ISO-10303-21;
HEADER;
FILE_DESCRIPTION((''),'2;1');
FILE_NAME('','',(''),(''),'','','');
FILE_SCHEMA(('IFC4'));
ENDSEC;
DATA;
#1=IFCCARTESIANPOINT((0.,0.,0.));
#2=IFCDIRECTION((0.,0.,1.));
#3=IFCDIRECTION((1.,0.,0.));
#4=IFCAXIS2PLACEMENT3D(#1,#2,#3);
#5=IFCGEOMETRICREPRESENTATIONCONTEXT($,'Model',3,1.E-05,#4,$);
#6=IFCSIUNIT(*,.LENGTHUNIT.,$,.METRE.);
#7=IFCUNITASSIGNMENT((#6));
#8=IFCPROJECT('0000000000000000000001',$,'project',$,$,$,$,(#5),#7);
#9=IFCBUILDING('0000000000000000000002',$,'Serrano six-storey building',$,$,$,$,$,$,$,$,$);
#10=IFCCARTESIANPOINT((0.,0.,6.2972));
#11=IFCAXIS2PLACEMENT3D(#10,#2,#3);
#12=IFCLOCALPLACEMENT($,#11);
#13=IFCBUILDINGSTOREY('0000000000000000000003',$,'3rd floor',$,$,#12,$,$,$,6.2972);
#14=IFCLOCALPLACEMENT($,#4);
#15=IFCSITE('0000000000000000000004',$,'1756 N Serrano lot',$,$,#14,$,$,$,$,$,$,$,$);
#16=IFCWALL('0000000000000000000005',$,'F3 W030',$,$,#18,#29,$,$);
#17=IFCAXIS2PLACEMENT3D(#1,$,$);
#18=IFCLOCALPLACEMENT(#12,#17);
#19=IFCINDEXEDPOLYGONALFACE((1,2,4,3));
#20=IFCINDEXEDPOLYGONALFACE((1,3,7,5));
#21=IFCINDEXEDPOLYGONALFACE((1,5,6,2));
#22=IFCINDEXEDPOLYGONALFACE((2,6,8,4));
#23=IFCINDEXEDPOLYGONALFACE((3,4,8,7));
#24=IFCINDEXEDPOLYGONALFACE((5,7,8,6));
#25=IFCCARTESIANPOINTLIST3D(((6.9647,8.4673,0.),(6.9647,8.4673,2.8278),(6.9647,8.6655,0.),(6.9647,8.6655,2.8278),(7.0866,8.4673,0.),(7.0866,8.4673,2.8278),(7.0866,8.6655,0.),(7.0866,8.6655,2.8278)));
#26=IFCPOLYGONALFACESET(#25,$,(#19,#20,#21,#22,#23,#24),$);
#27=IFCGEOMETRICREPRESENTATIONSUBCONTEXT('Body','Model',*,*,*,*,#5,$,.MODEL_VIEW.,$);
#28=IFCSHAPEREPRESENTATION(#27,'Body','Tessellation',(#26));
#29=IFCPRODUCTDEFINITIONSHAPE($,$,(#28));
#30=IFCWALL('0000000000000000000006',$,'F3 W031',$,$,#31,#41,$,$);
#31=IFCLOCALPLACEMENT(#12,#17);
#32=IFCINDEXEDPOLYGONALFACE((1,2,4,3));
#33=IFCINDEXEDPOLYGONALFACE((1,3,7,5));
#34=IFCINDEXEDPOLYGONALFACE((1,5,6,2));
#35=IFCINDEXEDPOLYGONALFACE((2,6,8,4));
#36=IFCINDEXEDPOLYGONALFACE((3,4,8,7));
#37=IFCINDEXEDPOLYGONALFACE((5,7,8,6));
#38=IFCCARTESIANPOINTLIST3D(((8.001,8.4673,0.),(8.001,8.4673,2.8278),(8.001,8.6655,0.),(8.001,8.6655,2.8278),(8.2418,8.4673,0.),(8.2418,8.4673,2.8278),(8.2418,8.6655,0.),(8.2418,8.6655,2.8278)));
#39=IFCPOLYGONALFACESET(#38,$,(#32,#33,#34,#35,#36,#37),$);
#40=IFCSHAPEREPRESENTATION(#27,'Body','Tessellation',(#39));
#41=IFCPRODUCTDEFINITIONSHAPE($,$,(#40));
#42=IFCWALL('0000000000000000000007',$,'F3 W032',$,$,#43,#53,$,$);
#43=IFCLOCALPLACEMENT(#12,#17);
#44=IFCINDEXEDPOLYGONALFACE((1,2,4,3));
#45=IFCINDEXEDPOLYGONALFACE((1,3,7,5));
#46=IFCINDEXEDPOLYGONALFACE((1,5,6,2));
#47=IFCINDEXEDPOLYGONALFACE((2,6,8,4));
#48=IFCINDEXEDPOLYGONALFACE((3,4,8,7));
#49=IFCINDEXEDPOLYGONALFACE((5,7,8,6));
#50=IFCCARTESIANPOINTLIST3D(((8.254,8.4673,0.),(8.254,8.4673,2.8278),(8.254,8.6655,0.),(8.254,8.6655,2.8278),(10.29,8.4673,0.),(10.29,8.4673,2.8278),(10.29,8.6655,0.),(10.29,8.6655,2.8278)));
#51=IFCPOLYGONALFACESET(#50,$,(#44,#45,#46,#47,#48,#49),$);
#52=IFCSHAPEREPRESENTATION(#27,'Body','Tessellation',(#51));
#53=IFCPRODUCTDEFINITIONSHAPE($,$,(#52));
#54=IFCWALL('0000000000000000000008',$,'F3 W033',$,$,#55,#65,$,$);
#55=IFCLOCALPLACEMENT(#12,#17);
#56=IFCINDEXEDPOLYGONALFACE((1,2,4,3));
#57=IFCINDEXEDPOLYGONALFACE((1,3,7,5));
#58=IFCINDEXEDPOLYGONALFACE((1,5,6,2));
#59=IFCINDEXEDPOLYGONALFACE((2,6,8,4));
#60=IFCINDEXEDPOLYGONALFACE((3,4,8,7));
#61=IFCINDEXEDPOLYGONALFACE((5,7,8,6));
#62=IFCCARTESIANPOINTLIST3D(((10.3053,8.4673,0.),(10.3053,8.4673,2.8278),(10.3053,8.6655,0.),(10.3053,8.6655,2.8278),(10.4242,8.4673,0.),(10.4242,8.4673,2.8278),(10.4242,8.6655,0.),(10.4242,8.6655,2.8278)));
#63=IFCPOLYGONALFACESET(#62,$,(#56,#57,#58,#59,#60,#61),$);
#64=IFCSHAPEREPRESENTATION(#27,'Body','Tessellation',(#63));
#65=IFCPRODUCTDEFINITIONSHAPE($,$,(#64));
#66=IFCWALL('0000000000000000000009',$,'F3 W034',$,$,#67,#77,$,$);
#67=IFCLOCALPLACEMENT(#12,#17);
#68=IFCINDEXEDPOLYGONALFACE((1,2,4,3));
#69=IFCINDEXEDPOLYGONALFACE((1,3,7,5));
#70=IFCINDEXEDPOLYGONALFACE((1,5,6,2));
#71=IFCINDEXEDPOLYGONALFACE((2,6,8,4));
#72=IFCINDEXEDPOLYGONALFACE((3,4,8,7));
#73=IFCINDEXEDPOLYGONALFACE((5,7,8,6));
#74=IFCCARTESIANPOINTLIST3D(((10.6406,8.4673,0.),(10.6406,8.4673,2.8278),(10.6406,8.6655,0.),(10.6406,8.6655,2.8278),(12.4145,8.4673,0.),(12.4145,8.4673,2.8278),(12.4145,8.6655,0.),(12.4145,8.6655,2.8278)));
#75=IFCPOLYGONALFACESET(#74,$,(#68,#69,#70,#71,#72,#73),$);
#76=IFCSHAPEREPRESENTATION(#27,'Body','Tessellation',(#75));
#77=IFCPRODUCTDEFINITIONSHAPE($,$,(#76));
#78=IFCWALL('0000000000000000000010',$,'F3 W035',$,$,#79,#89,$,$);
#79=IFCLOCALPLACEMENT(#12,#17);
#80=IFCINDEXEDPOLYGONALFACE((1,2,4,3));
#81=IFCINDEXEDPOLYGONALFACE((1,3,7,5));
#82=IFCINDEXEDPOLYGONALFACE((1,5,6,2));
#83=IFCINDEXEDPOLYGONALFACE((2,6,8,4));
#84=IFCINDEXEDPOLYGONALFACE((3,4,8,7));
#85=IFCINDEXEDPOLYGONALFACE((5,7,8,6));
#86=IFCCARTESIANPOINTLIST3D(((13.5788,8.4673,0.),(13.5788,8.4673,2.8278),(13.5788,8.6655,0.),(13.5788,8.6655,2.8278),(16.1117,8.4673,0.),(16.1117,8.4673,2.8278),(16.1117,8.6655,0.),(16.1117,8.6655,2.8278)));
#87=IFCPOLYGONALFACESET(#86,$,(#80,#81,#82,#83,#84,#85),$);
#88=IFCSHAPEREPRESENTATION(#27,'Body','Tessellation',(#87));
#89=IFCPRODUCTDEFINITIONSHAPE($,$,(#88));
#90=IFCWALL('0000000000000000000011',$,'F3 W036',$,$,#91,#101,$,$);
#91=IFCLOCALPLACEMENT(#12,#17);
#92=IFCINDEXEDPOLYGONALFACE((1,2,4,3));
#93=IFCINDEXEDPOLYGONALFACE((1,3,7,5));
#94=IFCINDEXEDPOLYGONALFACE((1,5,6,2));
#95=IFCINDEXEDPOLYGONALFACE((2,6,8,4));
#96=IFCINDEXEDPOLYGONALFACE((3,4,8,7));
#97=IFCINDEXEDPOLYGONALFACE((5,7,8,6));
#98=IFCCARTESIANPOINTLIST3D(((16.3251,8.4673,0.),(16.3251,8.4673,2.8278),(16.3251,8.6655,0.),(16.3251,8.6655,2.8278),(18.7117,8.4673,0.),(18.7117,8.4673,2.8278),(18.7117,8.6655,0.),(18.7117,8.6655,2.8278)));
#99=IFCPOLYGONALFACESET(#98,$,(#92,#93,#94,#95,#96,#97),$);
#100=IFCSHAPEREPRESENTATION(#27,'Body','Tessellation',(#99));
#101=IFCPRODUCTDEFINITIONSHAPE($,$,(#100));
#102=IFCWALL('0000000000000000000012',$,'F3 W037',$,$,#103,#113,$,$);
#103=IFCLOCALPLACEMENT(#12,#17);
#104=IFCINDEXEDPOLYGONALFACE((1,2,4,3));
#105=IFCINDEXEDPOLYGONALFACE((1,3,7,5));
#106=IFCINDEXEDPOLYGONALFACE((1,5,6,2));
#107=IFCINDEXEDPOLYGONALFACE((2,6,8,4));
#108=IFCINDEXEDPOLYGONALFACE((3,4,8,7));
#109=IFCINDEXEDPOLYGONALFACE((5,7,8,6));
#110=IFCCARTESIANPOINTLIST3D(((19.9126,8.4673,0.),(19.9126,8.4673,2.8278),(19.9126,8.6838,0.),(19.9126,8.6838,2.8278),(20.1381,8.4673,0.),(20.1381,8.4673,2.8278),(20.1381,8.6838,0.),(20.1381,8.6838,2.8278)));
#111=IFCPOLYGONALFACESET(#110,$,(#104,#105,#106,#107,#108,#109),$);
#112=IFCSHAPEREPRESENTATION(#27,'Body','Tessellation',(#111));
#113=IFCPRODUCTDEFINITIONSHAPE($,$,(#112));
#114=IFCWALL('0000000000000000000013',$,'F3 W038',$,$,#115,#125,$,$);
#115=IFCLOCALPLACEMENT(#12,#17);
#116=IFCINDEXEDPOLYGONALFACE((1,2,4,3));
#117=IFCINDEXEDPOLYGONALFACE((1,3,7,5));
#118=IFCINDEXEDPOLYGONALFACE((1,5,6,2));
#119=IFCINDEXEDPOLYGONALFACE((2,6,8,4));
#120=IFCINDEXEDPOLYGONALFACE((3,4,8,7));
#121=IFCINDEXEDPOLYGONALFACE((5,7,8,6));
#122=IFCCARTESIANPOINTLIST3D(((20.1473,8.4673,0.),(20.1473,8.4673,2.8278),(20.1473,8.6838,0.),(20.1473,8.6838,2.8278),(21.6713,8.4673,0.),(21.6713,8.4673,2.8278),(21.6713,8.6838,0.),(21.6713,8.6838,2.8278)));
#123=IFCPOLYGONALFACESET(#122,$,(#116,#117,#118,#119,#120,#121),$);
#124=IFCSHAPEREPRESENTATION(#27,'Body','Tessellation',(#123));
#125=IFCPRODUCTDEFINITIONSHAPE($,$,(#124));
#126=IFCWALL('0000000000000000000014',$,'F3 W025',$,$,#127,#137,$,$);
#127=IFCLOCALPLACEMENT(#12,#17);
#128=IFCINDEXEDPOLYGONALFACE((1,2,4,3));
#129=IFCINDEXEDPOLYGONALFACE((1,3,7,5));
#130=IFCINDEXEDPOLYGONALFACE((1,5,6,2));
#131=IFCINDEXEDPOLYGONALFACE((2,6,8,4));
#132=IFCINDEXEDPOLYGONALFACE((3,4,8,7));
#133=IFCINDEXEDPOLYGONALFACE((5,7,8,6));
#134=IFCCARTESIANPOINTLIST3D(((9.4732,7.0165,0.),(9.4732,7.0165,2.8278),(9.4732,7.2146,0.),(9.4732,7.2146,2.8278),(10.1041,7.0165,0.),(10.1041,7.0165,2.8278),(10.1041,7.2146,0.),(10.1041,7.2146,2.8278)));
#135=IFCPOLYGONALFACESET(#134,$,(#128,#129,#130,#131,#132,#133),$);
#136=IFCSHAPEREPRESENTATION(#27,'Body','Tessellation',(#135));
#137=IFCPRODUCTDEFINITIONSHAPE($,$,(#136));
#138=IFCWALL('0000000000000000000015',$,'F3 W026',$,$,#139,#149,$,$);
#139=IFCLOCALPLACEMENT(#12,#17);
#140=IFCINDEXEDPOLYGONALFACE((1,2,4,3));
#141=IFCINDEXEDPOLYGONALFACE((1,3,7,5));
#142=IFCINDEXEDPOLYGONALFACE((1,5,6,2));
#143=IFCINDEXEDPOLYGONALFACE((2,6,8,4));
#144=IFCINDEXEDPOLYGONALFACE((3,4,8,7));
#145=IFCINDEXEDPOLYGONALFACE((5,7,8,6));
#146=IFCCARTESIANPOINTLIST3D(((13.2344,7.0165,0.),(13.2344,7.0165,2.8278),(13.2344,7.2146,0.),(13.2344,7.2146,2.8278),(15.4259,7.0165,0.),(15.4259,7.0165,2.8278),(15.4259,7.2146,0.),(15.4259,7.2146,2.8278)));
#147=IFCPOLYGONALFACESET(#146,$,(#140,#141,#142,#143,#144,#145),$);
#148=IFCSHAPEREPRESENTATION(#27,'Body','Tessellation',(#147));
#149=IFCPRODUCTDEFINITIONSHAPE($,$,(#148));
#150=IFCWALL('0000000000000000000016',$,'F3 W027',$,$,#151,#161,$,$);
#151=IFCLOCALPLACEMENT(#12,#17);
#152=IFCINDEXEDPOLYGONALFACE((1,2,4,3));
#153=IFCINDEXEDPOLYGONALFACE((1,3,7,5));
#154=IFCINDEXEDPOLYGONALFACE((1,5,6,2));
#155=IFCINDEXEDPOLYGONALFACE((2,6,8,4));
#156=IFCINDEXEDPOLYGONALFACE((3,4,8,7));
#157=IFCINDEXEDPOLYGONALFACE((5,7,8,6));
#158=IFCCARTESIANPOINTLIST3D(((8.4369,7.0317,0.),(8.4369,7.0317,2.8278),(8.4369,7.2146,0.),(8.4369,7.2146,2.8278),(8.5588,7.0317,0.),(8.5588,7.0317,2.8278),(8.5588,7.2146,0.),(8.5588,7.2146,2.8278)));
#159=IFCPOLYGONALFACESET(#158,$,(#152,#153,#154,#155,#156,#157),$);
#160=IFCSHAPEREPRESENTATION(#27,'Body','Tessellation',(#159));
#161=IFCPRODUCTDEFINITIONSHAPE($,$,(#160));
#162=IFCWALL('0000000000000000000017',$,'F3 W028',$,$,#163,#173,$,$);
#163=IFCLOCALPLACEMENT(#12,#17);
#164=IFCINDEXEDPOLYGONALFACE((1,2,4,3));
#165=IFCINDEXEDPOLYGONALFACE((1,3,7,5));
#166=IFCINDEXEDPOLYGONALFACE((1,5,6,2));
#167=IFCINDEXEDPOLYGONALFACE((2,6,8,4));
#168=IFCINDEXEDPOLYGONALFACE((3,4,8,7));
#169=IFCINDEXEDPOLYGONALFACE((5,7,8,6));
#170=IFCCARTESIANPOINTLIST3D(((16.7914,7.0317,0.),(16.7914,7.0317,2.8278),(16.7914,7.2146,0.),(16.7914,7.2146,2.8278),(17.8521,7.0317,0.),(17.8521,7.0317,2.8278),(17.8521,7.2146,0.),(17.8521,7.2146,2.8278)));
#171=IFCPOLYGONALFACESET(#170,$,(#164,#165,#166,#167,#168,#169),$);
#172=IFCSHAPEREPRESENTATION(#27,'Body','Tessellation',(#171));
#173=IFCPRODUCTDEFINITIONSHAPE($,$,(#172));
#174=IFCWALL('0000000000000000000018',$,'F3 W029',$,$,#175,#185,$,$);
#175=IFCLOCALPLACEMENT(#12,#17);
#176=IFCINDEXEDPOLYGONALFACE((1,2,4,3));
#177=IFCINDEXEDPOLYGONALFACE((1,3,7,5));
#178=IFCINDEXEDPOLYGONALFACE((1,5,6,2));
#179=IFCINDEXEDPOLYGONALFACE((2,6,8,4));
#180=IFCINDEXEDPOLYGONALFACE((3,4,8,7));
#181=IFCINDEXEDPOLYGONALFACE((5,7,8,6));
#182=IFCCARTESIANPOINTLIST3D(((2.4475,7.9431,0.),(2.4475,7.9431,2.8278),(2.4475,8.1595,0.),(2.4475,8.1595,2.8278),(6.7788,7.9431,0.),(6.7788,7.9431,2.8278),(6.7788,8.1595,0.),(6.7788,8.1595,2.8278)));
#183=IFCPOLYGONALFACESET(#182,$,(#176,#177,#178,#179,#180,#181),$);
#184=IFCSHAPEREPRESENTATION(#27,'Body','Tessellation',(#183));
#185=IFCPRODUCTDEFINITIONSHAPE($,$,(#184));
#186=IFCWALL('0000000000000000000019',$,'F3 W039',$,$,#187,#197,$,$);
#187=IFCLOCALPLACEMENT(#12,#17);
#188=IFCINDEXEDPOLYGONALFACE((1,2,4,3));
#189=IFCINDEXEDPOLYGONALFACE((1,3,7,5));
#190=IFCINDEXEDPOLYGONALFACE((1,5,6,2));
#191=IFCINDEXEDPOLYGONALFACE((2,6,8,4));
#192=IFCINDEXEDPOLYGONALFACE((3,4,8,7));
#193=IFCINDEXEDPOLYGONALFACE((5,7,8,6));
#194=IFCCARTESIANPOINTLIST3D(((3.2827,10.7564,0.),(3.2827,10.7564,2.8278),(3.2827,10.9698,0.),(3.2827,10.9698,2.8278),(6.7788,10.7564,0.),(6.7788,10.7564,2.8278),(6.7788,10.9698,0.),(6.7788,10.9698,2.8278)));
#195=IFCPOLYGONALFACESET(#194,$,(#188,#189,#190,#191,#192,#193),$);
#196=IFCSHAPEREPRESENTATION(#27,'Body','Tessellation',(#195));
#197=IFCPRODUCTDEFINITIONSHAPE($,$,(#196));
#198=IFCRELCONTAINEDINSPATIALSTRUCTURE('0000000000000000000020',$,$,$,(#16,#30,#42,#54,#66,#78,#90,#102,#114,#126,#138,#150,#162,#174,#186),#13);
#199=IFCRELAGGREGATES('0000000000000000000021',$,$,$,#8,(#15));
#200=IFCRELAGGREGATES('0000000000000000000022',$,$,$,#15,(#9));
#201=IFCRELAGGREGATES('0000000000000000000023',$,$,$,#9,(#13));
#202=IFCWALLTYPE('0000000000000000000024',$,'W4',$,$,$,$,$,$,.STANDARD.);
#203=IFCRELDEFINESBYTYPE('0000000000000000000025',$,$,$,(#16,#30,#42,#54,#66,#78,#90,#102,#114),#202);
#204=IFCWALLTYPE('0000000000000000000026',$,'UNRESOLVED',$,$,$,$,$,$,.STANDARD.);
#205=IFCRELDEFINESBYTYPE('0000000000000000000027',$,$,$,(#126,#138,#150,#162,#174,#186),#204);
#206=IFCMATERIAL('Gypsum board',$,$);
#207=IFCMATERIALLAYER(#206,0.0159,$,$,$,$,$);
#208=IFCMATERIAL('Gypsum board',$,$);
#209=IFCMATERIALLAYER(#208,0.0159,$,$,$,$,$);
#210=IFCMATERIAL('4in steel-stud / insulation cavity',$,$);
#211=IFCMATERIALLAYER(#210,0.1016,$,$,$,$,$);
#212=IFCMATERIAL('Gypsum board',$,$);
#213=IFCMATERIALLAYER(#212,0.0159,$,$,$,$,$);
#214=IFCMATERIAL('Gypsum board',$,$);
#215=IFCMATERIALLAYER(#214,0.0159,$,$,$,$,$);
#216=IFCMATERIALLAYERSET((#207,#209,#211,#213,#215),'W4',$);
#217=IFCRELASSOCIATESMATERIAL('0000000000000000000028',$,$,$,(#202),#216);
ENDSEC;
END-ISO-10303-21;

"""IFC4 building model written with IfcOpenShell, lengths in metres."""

from ifc_helpers import new_model, si_unit, frame, origin_with_axes, place, context, subcontext, project, spatial, polyline, outline, extrude, material, layer, layer_set, type_object, element, save


model = new_model("IFC4")

# Units and contexts
model_context = context("Model", 3, precision=1e-05, world=origin_with_axes())
body_context = subcontext(model_context, "Body", "Model", "MODEL_VIEW")
ifc_project = project(units=[si_unit("LENGTHUNIT", "METRE")], contexts=[model_context])

# Site, building, storey
site_placement = place(None, origin_with_axes())
site = spatial("IfcSite", under=ifc_project, at=site_placement, Name="1756 N Serrano lot")
building = spatial("IfcBuilding", under=site, Name="Serrano six-storey building")
storey_placement = place(None, frame((0.0, 0.0, 6.2972), z_axis=(0.0, 0.0, 1.0), x_axis=(1.0, 0.0, 0.0)))
storey = spatial("IfcBuildingStorey", under=building, at=storey_placement, Name="3rd floor", Elevation=6.2972)

# Walls
ifc_material_1 = material(Name="Gypsum board")
ifc_layer_1 = layer(ifc_material_1, 0.0159)
ifc_material_2 = material(Name="Gypsum board")
ifc_layer_2 = layer(ifc_material_2, 0.0159)
ifc_material_3 = material(Name="4in steel-stud / insulation cavity")
ifc_layer_3 = layer(ifc_material_3, 0.1016)
ifc_material_4 = material(Name="Gypsum board")
ifc_layer_4 = layer(ifc_material_4, 0.0159)
ifc_material_5 = material(Name="Gypsum board")
ifc_layer_5 = layer(ifc_material_5, 0.0159)
ifc_layer_set = layer_set([ifc_layer_1, ifc_layer_2, ifc_layer_3, ifc_layer_4, ifc_layer_5], Name="W4")
wall_type_1 = type_object("IfcWallType", Name="W4", PredefinedType="STANDARD", material=ifc_layer_set)
wall_1_placement = place(storey_placement, frame((0.0, 0.0, -6.2972), z_axis=(0.0, 0.0, 1.0), x_axis=(1.0, 0.0, 0.0)))
element("IfcWall", 1, at=wall_1_placement, inside=storey, type_object=wall_type_1, Name="F3 W030", context=body_context, shape_type="SweptSolid", body=[
    extrude(outline(polyline([(7.0866, 8.6655), (7.0866, 8.4673), (6.9647, 8.4673), (6.9647, 8.6655), (7.0866, 8.6655)])), frame((0.0, 0.0, 6.2972)), (0.0, 0.0, 1.0), 2.8278),
])
wall_2_placement = place(storey_placement, frame((0.0, 0.0, -6.2972), z_axis=(0.0, 0.0, 1.0), x_axis=(1.0, 0.0, 0.0)))
element("IfcWall", 2, at=wall_2_placement, inside=storey, type_object=wall_type_1, Name="F3 W031", context=body_context, shape_type="SweptSolid", body=[
    extrude(outline(polyline([(8.2418, 8.6655), (8.2418, 8.4673), (8.001, 8.4673), (8.001, 8.6655), (8.2418, 8.6655)])), frame((0.0, 0.0, 6.2972)), (0.0, 0.0, 1.0), 2.8278),
])
wall_3_placement = place(storey_placement, frame((0.0, 0.0, -6.2972), z_axis=(0.0, 0.0, 1.0), x_axis=(1.0, 0.0, 0.0)))
element("IfcWall", 3, at=wall_3_placement, inside=storey, type_object=wall_type_1, Name="F3 W032", context=body_context, shape_type="SweptSolid", body=[
    extrude(outline(polyline([(10.29, 8.6655), (10.29, 8.4673), (8.254, 8.4673), (8.254, 8.6655), (10.29, 8.6655)])), frame((0.0, 0.0, 6.2972)), (0.0, 0.0, 1.0), 2.8278),
])
wall_4_placement = place(storey_placement, frame((0.0, 0.0, -6.2972), z_axis=(0.0, 0.0, 1.0), x_axis=(1.0, 0.0, 0.0)))
element("IfcWall", 4, at=wall_4_placement, inside=storey, type_object=wall_type_1, Name="F3 W033", context=body_context, shape_type="SweptSolid", body=[
    extrude(outline(polyline([(10.4242, 8.6655), (10.4242, 8.4673), (10.3053, 8.4673), (10.3053, 8.6655), (10.4242, 8.6655)])), frame((0.0, 0.0, 6.2972)), (0.0, 0.0, 1.0), 2.8278),
])
wall_5_placement = place(storey_placement, frame((0.0, 0.0, -6.2972), z_axis=(0.0, 0.0, 1.0), x_axis=(1.0, 0.0, 0.0)))
element("IfcWall", 5, at=wall_5_placement, inside=storey, type_object=wall_type_1, Name="F3 W034", context=body_context, shape_type="SweptSolid", body=[
    extrude(outline(polyline([(12.4145, 8.6655), (12.4145, 8.4673), (10.6406, 8.4673), (10.6406, 8.6655), (12.4145, 8.6655)])), frame((0.0, 0.0, 6.2972)), (0.0, 0.0, 1.0), 2.8278),
])
wall_6_placement = place(storey_placement, frame((0.0, 0.0, -6.2972), z_axis=(0.0, 0.0, 1.0), x_axis=(1.0, 0.0, 0.0)))
element("IfcWall", 6, at=wall_6_placement, inside=storey, type_object=wall_type_1, Name="F3 W035", context=body_context, shape_type="SweptSolid", body=[
    extrude(outline(polyline([(16.1117, 8.6655), (16.1117, 8.4673), (13.5788, 8.4673), (13.5788, 8.6655), (16.1117, 8.6655)])), frame((0.0, 0.0, 6.2972)), (0.0, 0.0, 1.0), 2.8278),
])
wall_7_placement = place(storey_placement, frame((0.0, 0.0, -6.2972), z_axis=(0.0, 0.0, 1.0), x_axis=(1.0, 0.0, 0.0)))
element("IfcWall", 7, at=wall_7_placement, inside=storey, type_object=wall_type_1, Name="F3 W036", context=body_context, shape_type="SweptSolid", body=[
    extrude(outline(polyline([(18.7117, 8.6655), (18.7117, 8.4673), (16.3251, 8.4673), (16.3251, 8.6655), (18.7117, 8.6655)])), frame((0.0, 0.0, 6.2972)), (0.0, 0.0, 1.0), 2.8278),
])
wall_8_placement = place(storey_placement, frame((0.0, 0.0, -6.2972), z_axis=(0.0, 0.0, 1.0), x_axis=(1.0, 0.0, 0.0)))
element("IfcWall", 8, at=wall_8_placement, inside=storey, type_object=wall_type_1, Name="F3 W037", context=body_context, shape_type="SweptSolid", body=[
    extrude(outline(polyline([(20.1381, 8.6838), (20.1381, 8.4673), (19.9126, 8.4673), (19.9126, 8.6838), (20.1381, 8.6838)])), frame((0.0, 0.0, 6.2972)), (0.0, 0.0, 1.0), 2.8278),
])
wall_9_placement = place(storey_placement, frame((0.0, 0.0, -6.2972), z_axis=(0.0, 0.0, 1.0), x_axis=(1.0, 0.0, 0.0)))
element("IfcWall", 9, at=wall_9_placement, inside=storey, type_object=wall_type_1, Name="F3 W038", context=body_context, shape_type="SweptSolid", body=[
    extrude(outline(polyline([(21.6713, 8.6838), (21.6713, 8.4673), (20.1473, 8.4673), (20.1473, 8.6838), (21.6713, 8.6838)])), frame((0.0, 0.0, 6.2972)), (0.0, 0.0, 1.0), 2.8278),
])
wall_type_2 = type_object("IfcWallType", Name="UNRESOLVED", PredefinedType="STANDARD")
wall_10_placement = place(storey_placement, frame((0.0, 0.0, -6.2972), z_axis=(0.0, 0.0, 1.0), x_axis=(1.0, 0.0, 0.0)))
element("IfcWall", 10, at=wall_10_placement, inside=storey, type_object=wall_type_2, Name="F3 W025", context=body_context, shape_type="SweptSolid", body=[
    extrude(outline(polyline([(10.1041, 7.2146), (10.1041, 7.0165), (9.4732, 7.0165), (9.4732, 7.2146), (10.1041, 7.2146)])), frame((0.0, 0.0, 6.2972)), (0.0, 0.0, 1.0), 2.8278),
])
wall_11_placement = place(storey_placement, frame((0.0, 0.0, -6.2972), z_axis=(0.0, 0.0, 1.0), x_axis=(1.0, 0.0, 0.0)))
element("IfcWall", 11, at=wall_11_placement, inside=storey, type_object=wall_type_2, Name="F3 W026", context=body_context, shape_type="SweptSolid", body=[
    extrude(outline(polyline([(15.4259, 7.2146), (15.4259, 7.0165), (13.2344, 7.0165), (13.2344, 7.2146), (15.4259, 7.2146)])), frame((0.0, 0.0, 6.2972)), (0.0, 0.0, 1.0), 2.8278),
])
wall_12_placement = place(storey_placement, frame((0.0, 0.0, -6.2972), z_axis=(0.0, 0.0, 1.0), x_axis=(1.0, 0.0, 0.0)))
element("IfcWall", 12, at=wall_12_placement, inside=storey, type_object=wall_type_2, Name="F3 W027", context=body_context, shape_type="SweptSolid", body=[
    extrude(outline(polyline([(8.5588, 7.2146), (8.5588, 7.0317), (8.4369, 7.0317), (8.4369, 7.2146), (8.5588, 7.2146)])), frame((0.0, 0.0, 6.2972)), (0.0, 0.0, 1.0), 2.8278),
])
wall_13_placement = place(storey_placement, frame((0.0, 0.0, -6.2972), z_axis=(0.0, 0.0, 1.0), x_axis=(1.0, 0.0, 0.0)))
element("IfcWall", 13, at=wall_13_placement, inside=storey, type_object=wall_type_2, Name="F3 W028", context=body_context, shape_type="SweptSolid", body=[
    extrude(outline(polyline([(17.8521, 7.2146), (17.8521, 7.0317), (16.7914, 7.0317), (16.7914, 7.2146), (17.8521, 7.2146)])), frame((0.0, 0.0, 6.2972)), (0.0, 0.0, 1.0), 2.8278),
])
wall_14_placement = place(storey_placement, frame((0.0, 0.0, -6.2972), z_axis=(0.0, 0.0, 1.0), x_axis=(1.0, 0.0, 0.0)))
element("IfcWall", 14, at=wall_14_placement, inside=storey, type_object=wall_type_2, Name="F3 W029", context=body_context, shape_type="SweptSolid", body=[
    extrude(outline(polyline([(6.7788, 8.1595), (6.7788, 7.9431), (2.4475, 7.9431), (2.4475, 8.1595), (6.7788, 8.1595)])), frame((0.0, 0.0, 6.2972)), (0.0, 0.0, 1.0), 2.8278),
])
wall_15_placement = place(storey_placement, frame((0.0, 0.0, -6.2972), z_axis=(0.0, 0.0, 1.0), x_axis=(1.0, 0.0, 0.0)))
element("IfcWall", 15, at=wall_15_placement, inside=storey, type_object=wall_type_2, Name="F3 W039", context=body_context, shape_type="SweptSolid", body=[
    extrude(outline(polyline([(6.7788, 10.9698), (6.7788, 10.7564), (3.2827, 10.7564), (3.2827, 10.9698), (6.7788, 10.9698)])), frame((0.0, 0.0, 6.2972)), (0.0, 0.0, 1.0), 2.8278),
])

save(model, "model.ifc")
